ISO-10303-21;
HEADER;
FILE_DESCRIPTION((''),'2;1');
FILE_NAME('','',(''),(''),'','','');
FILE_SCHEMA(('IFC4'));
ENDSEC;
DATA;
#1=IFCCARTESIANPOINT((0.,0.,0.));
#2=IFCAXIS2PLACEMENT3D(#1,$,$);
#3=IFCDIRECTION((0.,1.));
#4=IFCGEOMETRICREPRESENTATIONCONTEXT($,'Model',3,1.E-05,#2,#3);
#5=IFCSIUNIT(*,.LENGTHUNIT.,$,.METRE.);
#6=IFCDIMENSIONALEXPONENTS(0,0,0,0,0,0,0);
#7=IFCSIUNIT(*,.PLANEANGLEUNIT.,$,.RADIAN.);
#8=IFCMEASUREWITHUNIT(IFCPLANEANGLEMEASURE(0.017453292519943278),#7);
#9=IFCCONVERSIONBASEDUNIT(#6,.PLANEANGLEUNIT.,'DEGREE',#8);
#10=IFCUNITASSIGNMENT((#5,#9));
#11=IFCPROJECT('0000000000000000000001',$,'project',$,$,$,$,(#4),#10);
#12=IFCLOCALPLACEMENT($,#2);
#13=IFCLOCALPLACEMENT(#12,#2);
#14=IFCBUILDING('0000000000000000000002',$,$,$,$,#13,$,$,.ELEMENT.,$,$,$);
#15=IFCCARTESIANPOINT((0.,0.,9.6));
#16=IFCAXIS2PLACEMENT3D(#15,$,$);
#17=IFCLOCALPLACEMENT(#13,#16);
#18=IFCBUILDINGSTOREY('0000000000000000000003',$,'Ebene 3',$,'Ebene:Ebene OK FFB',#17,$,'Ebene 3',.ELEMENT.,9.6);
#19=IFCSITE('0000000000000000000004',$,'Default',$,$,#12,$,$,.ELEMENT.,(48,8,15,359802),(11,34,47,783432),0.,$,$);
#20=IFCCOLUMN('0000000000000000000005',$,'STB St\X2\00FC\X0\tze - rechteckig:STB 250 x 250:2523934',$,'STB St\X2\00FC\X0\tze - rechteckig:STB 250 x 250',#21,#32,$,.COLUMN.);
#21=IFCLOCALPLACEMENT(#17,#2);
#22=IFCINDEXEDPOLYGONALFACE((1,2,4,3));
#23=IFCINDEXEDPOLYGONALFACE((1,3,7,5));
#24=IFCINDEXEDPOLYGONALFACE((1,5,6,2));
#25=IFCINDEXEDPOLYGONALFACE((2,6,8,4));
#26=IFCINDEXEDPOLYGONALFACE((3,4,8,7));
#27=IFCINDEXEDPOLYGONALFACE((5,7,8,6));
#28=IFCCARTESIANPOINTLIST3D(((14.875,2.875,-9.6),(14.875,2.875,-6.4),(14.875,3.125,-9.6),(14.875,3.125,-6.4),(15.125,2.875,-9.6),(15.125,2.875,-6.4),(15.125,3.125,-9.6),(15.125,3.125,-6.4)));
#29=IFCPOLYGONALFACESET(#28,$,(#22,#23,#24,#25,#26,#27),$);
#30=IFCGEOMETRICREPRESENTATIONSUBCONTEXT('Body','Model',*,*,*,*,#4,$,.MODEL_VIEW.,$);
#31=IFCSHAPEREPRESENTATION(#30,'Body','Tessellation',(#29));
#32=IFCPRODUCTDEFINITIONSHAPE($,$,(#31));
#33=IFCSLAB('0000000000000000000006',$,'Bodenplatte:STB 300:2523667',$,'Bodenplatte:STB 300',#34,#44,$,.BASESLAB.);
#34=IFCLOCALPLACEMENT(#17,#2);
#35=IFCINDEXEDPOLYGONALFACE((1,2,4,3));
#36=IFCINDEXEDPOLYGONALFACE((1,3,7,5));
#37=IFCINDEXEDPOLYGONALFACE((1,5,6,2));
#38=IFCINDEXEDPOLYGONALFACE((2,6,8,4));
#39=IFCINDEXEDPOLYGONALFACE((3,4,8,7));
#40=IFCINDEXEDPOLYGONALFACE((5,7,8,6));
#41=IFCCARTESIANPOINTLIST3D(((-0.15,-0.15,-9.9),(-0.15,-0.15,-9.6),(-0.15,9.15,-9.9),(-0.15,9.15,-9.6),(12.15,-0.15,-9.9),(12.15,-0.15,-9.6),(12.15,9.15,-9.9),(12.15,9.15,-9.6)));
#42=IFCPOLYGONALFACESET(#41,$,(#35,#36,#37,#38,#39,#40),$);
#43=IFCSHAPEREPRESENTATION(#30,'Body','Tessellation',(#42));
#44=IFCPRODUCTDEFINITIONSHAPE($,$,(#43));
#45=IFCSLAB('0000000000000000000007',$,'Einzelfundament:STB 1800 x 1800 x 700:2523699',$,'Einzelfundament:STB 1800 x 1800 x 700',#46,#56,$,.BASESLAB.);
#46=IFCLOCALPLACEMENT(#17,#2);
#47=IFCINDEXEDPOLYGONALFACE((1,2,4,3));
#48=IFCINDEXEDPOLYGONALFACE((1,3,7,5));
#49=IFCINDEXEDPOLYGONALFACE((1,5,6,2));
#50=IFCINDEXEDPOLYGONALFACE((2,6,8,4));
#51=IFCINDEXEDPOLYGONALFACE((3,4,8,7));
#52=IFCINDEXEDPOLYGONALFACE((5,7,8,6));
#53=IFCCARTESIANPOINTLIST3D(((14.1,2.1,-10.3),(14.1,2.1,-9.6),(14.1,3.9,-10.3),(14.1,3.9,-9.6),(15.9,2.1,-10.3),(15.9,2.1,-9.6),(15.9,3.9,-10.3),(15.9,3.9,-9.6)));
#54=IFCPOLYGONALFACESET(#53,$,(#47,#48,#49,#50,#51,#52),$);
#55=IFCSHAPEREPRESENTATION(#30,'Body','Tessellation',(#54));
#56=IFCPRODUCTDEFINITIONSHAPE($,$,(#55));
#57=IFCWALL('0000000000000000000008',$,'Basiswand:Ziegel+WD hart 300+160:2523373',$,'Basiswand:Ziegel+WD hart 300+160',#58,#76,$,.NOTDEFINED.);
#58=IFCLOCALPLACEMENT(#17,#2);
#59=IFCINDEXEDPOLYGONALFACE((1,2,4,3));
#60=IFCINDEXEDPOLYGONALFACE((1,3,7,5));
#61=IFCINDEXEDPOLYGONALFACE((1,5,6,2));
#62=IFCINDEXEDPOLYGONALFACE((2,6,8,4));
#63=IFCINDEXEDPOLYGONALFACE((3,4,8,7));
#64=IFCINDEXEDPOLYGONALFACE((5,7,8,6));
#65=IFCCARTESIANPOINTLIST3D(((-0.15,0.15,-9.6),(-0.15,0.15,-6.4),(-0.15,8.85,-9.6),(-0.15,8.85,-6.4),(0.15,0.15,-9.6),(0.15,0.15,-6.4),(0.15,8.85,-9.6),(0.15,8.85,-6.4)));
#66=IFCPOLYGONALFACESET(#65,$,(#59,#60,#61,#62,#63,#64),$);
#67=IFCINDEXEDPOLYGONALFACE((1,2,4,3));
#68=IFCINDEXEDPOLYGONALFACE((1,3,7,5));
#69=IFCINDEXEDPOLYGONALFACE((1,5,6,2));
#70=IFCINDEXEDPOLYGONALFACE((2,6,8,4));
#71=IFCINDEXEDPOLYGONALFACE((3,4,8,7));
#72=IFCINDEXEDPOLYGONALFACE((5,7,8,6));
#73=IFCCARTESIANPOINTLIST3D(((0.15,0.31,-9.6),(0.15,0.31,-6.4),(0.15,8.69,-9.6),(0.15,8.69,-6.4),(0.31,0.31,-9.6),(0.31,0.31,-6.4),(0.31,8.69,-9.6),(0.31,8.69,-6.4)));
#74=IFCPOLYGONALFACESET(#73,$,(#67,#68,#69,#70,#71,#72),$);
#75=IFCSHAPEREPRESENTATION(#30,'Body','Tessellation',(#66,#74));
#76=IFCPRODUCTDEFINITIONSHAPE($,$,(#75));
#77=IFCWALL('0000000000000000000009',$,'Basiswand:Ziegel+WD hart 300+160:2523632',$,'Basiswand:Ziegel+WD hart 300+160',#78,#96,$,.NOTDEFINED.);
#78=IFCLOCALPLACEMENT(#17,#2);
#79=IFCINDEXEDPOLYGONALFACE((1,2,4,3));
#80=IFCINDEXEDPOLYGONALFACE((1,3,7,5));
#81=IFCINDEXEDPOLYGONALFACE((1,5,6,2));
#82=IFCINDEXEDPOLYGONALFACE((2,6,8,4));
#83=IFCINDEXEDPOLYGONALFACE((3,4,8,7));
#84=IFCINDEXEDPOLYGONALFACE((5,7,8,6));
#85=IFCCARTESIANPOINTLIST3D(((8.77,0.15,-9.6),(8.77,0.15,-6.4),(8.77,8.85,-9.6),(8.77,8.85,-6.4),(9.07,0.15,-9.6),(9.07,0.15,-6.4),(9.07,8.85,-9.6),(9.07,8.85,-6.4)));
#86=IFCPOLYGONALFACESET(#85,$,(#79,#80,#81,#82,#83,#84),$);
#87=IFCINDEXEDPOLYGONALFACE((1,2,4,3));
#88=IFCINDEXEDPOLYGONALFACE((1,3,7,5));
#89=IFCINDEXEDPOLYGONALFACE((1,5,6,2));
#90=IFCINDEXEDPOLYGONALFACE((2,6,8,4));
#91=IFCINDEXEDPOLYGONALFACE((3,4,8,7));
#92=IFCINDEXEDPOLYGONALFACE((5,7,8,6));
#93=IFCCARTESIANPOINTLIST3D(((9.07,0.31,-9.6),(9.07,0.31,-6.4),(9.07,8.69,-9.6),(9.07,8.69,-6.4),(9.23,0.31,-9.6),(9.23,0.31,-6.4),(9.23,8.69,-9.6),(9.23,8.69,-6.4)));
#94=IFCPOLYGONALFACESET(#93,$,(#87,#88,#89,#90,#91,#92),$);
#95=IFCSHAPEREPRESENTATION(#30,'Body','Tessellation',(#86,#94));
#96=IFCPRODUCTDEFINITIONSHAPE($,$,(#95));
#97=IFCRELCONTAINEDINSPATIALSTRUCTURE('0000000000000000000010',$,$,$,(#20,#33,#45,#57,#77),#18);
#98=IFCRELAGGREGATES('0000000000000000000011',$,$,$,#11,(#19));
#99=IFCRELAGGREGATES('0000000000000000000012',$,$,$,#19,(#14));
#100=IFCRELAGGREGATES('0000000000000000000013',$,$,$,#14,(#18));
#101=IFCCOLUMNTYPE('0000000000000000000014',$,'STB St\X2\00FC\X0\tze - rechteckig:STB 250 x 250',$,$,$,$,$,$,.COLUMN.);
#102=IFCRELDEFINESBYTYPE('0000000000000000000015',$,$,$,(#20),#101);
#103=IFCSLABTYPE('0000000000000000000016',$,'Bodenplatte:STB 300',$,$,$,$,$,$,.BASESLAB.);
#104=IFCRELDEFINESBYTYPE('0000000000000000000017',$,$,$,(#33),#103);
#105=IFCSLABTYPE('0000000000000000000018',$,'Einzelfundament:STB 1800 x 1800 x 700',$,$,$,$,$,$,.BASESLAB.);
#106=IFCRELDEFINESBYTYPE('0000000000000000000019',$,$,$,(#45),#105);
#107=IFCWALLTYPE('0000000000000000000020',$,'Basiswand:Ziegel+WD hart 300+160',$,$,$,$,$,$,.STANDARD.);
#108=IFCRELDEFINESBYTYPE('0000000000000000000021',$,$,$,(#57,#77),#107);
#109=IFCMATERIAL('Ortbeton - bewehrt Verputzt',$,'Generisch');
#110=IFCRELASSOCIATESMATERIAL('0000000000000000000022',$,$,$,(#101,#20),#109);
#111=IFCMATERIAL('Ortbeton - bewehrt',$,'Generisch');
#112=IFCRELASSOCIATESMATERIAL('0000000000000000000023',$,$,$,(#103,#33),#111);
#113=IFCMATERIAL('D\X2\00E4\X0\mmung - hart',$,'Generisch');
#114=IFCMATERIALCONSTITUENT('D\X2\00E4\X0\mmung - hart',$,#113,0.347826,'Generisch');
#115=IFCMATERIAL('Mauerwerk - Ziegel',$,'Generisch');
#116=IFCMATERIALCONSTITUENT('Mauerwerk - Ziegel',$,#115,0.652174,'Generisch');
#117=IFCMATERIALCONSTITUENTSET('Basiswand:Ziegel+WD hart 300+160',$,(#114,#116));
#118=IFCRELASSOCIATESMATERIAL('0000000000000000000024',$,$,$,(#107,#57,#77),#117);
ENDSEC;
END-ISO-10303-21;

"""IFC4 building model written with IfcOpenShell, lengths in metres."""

from ifc_helpers import new_model, entity, si_unit, converted_unit, direction, frame, origin, place, context, subcontext, project, spatial, indexed_curve, outline, extrude, source, transform, mapped, material, constituent, constituent_set, type_object, type_shapes, element, save


model = new_model("IFC4")

# Units and contexts
model_context = context("Model", 3, precision=1e-05, world=origin(), true_north=direction((0.0, 1.0)))
body_context = subcontext(model_context, "Body", "Model", "MODEL_VIEW")
ifc_project = project(units=[si_unit("LENGTHUNIT", "METRE"), converted_unit("PLANEANGLEUNIT", "DEGREE", entity("IfcPlaneAngleMeasure", 0.017453292519943278), si_unit("PLANEANGLEUNIT", "RADIAN"), dimensions=[0, 0, 0, 0, 0, 0, 0])], contexts=[model_context])

# Site, building, storey
site_placement = place(None, origin())
site = spatial("IfcSite", under=ifc_project, at=site_placement, Name="Default", CompositionType="ELEMENT", RefLatitude=(48, 8, 15, 359802), RefLongitude=(11, 34, 47, 783432), RefElevation=0.0)
building_placement = place(site_placement, origin())
building = spatial("IfcBuilding", under=site, at=building_placement, CompositionType="ELEMENT")
storey_placement = place(building_placement, frame((0.0, 0.0, 9.6)))
storey = spatial("IfcBuildingStorey", under=building, at=storey_placement, Name="Ebene 3", ObjectType="Ebene:Ebene OK FFB", LongName="Ebene 3", CompositionType="ELEMENT", Elevation=9.6)

# Column
ifc_material_1 = material(Name="Ortbeton - bewehrt Verputzt", Category="Generisch")
column_type = type_object("IfcColumnType", Name="STB Stütze - rechteckig:STB 250 x 250", PredefinedType="COLUMN", material=ifc_material_1)
shared_shape = source(origin(), body_context, "Body", "SweptSolid", [
    extrude(outline(indexed_curve([(-0.125, -0.125), (0.125, -0.125), (0.125, 0.125), (-0.125, 0.125), (-0.125, -0.125)], self_intersect=False)), frame((0.0, 0.0, 0.0), z_axis=(0.0, 0.0, 1.0), x_axis=(-1.0, 0.0, 0.0)), (0.0, 0.0, 1.0), 3.2),
])
type_shapes(column_type, [shared_shape])
column_placement = place(storey_placement, frame((15.0, 3.0, -9.6)))
element("IfcColumn", 1, at=column_placement, inside=storey, type_object=column_type, material=ifc_material_1, Name="STB Stütze - rechteckig:STB 250 x 250:2523934", ObjectType="STB Stütze - rechteckig:STB 250 x 250", PredefinedType="COLUMN", context=body_context, shape_type="MappedRepresentation", body=[
    mapped(shared_shape, transform((0.0, 0.0, 0.0), scale=1.0)),
])

# Slabs
ifc_material_2 = material(Name="Ortbeton - bewehrt", Category="Generisch")
slab_type_1 = type_object("IfcSlabType", Name="Bodenplatte:STB 300", PredefinedType="BASESLAB", material=ifc_material_2)
slab_1_placement = place(storey_placement, origin())
element("IfcSlab", 2, at=slab_1_placement, inside=storey, type_object=slab_type_1, material=ifc_material_2, Name="Bodenplatte:STB 300:2523667", ObjectType="Bodenplatte:STB 300", PredefinedType="BASESLAB", context=body_context, shape_type="SweptSolid", body=[
    extrude(outline(indexed_curve([(-4.65, -6.15), (4.65, -6.15), (4.65, 6.15), (-4.65, 6.15), (-4.65, -6.15)], self_intersect=False)), frame((6.0, 4.5, -9.6), z_axis=(0.0, 0.0, -1.0), x_axis=(0.0, 1.0, 0.0)), (0.0, 0.0, 1.0), 0.3),
])
slab_type_2 = type_object("IfcSlabType", Name="Einzelfundament:STB 1800 x 1800 x 700", PredefinedType="BASESLAB")
slab_2_placement = place(storey_placement, origin())
element("IfcSlab", 3, at=slab_2_placement, inside=storey, type_object=slab_type_2, Name="Einzelfundament:STB 1800 x 1800 x 700:2523699", ObjectType="Einzelfundament:STB 1800 x 1800 x 700", PredefinedType="BASESLAB", context=body_context, shape_type="SweptSolid", body=[
    extrude(outline(indexed_curve([(-0.9, -0.9), (0.9, -0.9), (0.9, 0.9), (-0.9, 0.9), (-0.9, -0.9)], self_intersect=False)), frame((15.0, 3.0, -10.3), z_axis=(0.0, 0.0, 1.0), x_axis=(-1.0, 0.0, 0.0)), (0.0, 0.0, 1.0), 0.7),
])

# Shared definitions
ifc_material_3 = material(Name="Dämmung - hart", Category="Generisch")
ifc_constituent_1 = constituent(ifc_material_3, Name="Dämmung - hart", Category="Generisch", fraction=0.347826)
ifc_material_4 = material(Name="Mauerwerk - Ziegel", Category="Generisch")
ifc_constituent_2 = constituent(ifc_material_4, Name="Mauerwerk - Ziegel", Category="Generisch", fraction=0.652174)
ifc_constituent_set = constituent_set(constituents=[ifc_constituent_1, ifc_constituent_2], Name="Basiswand:Ziegel+WD hart 300+160")
wall_type = type_object("IfcWallType", Name="Basiswand:Ziegel+WD hart 300+160", PredefinedType="STANDARD", material=ifc_constituent_set)

# Walls
wall_1_placement = place(storey_placement, frame((0.08, 8.69, -9.6), z_axis=(0.0, 0.0, 1.0), x_axis=(0.0, -1.0, 0.0)))
element("IfcWall", 4, at=wall_1_placement, inside=storey, type_object=wall_type, material=ifc_constituent_set, Name="Basiswand:Ziegel+WD hart 300+160:2523373", ObjectType="Basiswand:Ziegel+WD hart 300+160", PredefinedType="NOTDEFINED", context=body_context, shape_type="SweptSolid", body=[
    extrude(outline(indexed_curve([(-0.15, -4.35), (0.15, -4.35), (0.15, 4.35), (-0.15, 4.35), (-0.15, -4.35)], self_intersect=False)), frame((4.19, -0.08, 0.0), z_axis=(0.0, 0.0, 1.0), x_axis=(0.0, 1.0, 0.0)), (0.0, 0.0, 1.0), 3.2),
    extrude(outline(indexed_curve([(-0.08, -4.19), (0.08, -4.19), (0.08, 4.19), (-0.08, 4.19), (-0.08, -4.19)], self_intersect=False)), frame((4.19, 0.15, 0.0), z_axis=(0.0, 0.0, 1.0), x_axis=(0.0, -1.0, 0.0)), (0.0, 0.0, 1.0), 3.2),
])
wall_2_placement = place(storey_placement, frame((9.0, 8.69, -9.6), z_axis=(0.0, 0.0, 1.0), x_axis=(0.0, -1.0, 0.0)))
element("IfcWall", 5, at=wall_2_placement, inside=storey, type_object=wall_type, material=ifc_constituent_set, Name="Basiswand:Ziegel+WD hart 300+160:2523632", ObjectType="Basiswand:Ziegel+WD hart 300+160", PredefinedType="NOTDEFINED", context=body_context, shape_type="SweptSolid", body=[
    extrude(outline(indexed_curve([(-0.15, -4.35), (0.15, -4.35), (0.15, 4.35), (-0.15, 4.35), (-0.15, -4.35)], self_intersect=False)), frame((4.19, -0.08, 0.0), z_axis=(0.0, 0.0, 1.0), x_axis=(0.0, 1.0, 0.0)), (0.0, 0.0, 1.0), 3.2),
    extrude(outline(indexed_curve([(-0.08, -4.19), (0.08, -4.19), (0.08, 4.19), (-0.08, 4.19), (-0.08, -4.19)], self_intersect=False)), frame((4.19, 0.15, 0.0), z_axis=(0.0, 0.0, 1.0), x_axis=(0.0, -1.0, 0.0)), (0.0, 0.0, 1.0), 3.2),
])

save(model, "model.ifc")
